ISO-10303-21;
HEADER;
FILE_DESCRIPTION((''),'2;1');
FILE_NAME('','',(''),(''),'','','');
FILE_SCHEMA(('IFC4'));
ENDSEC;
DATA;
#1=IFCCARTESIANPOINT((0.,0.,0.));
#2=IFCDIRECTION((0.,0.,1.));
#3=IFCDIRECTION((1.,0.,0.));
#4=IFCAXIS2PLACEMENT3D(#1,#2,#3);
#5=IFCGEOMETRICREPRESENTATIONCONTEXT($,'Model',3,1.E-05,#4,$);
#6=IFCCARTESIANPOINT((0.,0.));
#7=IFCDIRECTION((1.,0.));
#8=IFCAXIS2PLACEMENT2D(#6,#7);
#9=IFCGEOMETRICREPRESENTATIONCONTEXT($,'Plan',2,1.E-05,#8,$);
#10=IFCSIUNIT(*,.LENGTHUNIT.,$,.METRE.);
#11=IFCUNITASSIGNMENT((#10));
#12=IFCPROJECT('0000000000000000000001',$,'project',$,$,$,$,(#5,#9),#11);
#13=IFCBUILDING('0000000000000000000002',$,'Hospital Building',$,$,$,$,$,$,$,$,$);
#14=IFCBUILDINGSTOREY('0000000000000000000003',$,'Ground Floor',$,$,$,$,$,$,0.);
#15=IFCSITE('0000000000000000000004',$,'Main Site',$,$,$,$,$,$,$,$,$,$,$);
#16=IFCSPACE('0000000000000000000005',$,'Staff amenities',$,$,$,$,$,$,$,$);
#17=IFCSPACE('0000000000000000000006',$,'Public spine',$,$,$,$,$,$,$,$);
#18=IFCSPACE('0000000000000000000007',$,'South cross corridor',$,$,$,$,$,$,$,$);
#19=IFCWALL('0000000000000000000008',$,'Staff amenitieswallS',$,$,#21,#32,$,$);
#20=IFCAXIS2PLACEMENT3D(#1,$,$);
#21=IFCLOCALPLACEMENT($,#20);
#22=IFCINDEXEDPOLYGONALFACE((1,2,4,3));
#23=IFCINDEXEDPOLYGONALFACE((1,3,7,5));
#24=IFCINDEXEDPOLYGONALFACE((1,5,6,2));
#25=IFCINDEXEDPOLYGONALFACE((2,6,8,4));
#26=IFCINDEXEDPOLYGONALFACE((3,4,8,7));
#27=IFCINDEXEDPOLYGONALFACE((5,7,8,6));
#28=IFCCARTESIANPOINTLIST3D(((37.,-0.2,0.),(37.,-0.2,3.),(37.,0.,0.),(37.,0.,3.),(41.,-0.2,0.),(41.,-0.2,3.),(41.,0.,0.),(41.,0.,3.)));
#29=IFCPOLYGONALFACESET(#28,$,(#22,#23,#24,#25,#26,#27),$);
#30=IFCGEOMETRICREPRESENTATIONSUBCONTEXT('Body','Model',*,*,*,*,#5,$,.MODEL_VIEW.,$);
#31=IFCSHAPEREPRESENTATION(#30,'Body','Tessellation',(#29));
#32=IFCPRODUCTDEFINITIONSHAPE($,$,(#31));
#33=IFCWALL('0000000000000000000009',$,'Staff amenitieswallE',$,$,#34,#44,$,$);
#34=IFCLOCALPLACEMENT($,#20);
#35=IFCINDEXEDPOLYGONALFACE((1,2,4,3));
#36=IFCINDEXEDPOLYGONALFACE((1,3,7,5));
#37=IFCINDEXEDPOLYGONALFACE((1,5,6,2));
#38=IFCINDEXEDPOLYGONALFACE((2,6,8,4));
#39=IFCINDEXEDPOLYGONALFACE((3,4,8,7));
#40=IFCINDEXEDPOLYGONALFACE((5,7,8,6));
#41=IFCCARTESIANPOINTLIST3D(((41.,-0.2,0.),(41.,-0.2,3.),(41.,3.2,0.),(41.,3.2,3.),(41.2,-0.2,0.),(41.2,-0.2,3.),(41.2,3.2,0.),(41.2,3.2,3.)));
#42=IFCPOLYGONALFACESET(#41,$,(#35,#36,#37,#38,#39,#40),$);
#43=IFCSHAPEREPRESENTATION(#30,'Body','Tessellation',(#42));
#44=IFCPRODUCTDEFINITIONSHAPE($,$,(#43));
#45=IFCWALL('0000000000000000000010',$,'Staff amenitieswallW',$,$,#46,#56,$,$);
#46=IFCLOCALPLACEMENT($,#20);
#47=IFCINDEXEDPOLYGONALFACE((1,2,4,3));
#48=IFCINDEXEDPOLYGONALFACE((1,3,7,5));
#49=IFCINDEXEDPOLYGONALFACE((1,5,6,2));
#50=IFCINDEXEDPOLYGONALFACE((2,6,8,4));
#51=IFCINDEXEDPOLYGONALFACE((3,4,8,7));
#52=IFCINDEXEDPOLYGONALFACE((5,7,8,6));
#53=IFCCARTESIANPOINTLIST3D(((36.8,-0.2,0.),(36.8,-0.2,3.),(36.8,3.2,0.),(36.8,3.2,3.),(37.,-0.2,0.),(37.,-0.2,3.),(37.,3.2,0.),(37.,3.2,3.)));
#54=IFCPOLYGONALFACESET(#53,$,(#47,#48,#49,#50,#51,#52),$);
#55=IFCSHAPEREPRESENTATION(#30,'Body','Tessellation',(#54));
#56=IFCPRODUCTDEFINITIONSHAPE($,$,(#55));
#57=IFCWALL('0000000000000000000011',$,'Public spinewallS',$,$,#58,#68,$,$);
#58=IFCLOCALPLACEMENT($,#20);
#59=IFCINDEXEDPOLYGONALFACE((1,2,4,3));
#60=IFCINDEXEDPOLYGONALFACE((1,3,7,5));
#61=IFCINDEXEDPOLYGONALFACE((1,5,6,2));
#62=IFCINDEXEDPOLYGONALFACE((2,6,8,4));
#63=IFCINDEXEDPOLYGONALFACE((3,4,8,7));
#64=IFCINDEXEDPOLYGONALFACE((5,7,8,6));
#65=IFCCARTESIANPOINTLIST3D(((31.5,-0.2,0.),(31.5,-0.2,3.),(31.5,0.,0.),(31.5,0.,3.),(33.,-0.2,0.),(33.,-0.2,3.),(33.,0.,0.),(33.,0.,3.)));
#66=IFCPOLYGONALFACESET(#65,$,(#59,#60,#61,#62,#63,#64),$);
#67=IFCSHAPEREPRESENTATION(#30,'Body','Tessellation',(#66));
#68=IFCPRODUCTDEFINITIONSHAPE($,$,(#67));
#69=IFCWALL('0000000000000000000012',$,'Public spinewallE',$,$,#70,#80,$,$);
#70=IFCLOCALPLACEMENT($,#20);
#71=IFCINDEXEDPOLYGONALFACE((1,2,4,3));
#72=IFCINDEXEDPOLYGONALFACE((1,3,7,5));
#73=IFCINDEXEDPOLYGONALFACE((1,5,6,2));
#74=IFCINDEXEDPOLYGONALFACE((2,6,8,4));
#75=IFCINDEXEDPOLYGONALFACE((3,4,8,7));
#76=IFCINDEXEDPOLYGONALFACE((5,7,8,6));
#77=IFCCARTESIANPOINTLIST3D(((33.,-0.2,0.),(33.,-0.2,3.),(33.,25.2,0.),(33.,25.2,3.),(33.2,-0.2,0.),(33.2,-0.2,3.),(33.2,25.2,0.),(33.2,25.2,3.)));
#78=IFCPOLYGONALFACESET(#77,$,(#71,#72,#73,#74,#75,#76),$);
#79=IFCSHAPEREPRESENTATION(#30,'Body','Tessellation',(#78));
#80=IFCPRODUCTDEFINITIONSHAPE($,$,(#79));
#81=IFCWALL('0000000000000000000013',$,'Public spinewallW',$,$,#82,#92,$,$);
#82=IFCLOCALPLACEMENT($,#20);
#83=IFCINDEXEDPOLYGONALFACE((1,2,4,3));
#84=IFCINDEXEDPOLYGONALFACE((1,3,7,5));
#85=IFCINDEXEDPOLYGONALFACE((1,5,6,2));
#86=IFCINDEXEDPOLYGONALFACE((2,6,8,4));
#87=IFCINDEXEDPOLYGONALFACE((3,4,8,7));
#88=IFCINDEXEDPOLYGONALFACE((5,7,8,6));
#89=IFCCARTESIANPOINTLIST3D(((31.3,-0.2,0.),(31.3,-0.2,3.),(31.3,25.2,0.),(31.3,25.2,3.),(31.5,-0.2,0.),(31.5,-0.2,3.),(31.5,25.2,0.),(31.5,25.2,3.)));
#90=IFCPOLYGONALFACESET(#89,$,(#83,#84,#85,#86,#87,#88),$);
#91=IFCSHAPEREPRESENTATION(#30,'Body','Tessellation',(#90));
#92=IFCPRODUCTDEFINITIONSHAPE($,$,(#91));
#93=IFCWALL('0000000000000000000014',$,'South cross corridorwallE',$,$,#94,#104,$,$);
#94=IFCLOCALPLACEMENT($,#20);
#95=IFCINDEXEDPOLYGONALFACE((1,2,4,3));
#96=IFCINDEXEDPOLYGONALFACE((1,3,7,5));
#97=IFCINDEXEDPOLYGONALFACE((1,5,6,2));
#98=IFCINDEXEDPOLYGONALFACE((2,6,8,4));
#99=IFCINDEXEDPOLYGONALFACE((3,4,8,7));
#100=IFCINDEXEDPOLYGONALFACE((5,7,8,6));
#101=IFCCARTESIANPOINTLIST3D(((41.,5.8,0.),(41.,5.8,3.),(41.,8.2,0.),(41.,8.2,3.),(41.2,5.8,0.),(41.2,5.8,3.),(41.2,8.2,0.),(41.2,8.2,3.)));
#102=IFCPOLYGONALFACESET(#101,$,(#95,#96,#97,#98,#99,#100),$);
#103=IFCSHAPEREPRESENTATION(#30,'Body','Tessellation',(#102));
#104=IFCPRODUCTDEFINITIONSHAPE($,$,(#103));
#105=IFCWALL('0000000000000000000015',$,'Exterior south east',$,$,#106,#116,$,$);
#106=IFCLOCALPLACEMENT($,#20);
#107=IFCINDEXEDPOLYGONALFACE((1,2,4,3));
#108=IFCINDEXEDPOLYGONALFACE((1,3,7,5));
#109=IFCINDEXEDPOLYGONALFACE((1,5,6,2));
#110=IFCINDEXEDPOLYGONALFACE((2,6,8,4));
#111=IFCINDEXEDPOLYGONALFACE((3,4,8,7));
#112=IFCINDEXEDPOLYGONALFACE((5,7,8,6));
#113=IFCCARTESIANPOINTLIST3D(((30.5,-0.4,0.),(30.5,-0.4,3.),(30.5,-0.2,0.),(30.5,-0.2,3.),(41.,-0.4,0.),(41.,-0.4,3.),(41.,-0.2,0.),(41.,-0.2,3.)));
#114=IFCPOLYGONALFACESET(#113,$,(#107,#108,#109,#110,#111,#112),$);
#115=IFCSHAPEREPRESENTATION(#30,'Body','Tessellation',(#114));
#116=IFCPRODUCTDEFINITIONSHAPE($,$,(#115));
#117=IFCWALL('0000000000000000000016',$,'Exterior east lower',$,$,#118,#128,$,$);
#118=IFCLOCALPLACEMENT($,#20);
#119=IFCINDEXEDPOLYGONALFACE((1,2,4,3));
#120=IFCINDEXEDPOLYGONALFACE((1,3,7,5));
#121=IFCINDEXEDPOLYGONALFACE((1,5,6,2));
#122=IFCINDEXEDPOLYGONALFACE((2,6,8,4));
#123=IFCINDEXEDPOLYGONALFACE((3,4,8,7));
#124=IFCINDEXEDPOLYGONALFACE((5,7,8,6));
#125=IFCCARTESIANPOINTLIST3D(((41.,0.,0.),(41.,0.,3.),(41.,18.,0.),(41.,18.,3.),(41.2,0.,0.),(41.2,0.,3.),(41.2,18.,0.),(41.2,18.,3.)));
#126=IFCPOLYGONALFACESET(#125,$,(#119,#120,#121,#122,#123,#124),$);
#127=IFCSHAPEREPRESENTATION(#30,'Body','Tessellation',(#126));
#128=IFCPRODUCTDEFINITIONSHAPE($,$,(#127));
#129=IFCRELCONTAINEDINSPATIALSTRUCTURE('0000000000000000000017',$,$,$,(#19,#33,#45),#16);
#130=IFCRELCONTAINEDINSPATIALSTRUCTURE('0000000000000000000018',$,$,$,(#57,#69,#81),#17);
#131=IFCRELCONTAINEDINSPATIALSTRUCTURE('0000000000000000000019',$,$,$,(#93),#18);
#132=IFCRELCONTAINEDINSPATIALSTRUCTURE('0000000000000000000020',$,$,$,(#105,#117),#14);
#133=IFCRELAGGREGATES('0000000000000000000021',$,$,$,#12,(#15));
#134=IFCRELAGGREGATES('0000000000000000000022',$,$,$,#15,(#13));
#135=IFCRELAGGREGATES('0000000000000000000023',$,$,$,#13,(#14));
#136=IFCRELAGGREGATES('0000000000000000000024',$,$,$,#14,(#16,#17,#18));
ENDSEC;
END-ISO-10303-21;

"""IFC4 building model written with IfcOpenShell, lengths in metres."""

from ifc_helpers import new_model, si_unit, frame, origin_with_axes, origin_2d_with_axis, place, context, subcontext, project, spatial, indexed_curve, outline, extrude, element, save


model = new_model("IFC4")

# Units and contexts
model_context = context("Model", 3, precision=1e-05, world=origin_with_axes())
plan_context = context("Plan", 2, precision=1e-05, world=origin_2d_with_axis())
body_context = subcontext(model_context, "Body", "Model", "MODEL_VIEW")
ifc_project = project(units=[si_unit("LENGTHUNIT", "METRE")], contexts=[model_context, plan_context])

# Site, building, storey
site = spatial("IfcSite", under=ifc_project, Name="Main Site")
building = spatial("IfcBuilding", under=site, Name="Hospital Building")
storey = spatial("IfcBuildingStorey", under=building, Name="Ground Floor", Elevation=0.0)

# Shared definitions
space_1 = spatial("IfcSpace", under=storey, Name="Staff amenities")

# Walls
wall_1_placement = place(None, frame((37.0, -0.2, 0.0), z_axis=(0.0, 0.0, 1.0), x_axis=(1.0, 0.0, 0.0)))
element("IfcWall", 1, at=wall_1_placement, inside=space_1, Name="Staff amenitieswallS", context=body_context, shape_type="SweptSolid", body=[
    extrude(outline(indexed_curve([(0.0, 0.0), (0.0, 0.2), (4.0, 0.2), (4.0, 0.0), (0.0, 0.0)], self_intersect=False)), origin_with_axes(), (0.0, 0.0, 1.0), 3.0),
])
for number, where, z_axis, x_axis, name in (
    (2, (41.2, -0.2, 0.0), (0.0, 0.0, 1.0), (0.0, 1.0, 0.0), "Staff amenitieswallE"),
    (3, (37.0, -0.2, 0.0), (0.0, 0.0, 1.0), (0.0, 1.0, 0.0), "Staff amenitieswallW"),
):
    element("IfcWall", number, at=place(None, frame(where, z_axis=z_axis, x_axis=x_axis)), inside=space_1, Name=name, context=body_context, shape_type="SweptSolid", body=[
        extrude(outline(indexed_curve([(0.0, 0.0), (0.0, 0.2), (3.4, 0.2), (3.4, 0.0), (0.0, 0.0)], self_intersect=False)), origin_with_axes(), (0.0, 0.0, 1.0), 3.0),
    ])

# Shared definitions
space_2 = spatial("IfcSpace", under=storey, Name="Public spine")

# Walls
wall_2_placement = place(None, frame((31.5, -0.2, 0.0), z_axis=(0.0, 0.0, 1.0), x_axis=(1.0, 0.0, 0.0)))
element("IfcWall", 4, at=wall_2_placement, inside=space_2, Name="Public spinewallS", context=body_context, shape_type="SweptSolid", body=[
    extrude(outline(indexed_curve([(0.0, 0.0), (0.0, 0.2), (1.5, 0.2), (1.5, 0.0), (0.0, 0.0)], self_intersect=False)), origin_with_axes(), (0.0, 0.0, 1.0), 3.0),
])
for number, where, z_axis, x_axis, name in (
    (5, (33.2, -0.2, 0.0), (0.0, 0.0, 1.0), (0.0, 1.0, 0.0), "Public spinewallE"),
    (6, (31.5, -0.2, 0.0), (0.0, 0.0, 1.0), (0.0, 1.0, 0.0), "Public spinewallW"),
):
    element("IfcWall", number, at=place(None, frame(where, z_axis=z_axis, x_axis=x_axis)), inside=space_2, Name=name, context=body_context, shape_type="SweptSolid", body=[
        extrude(outline(indexed_curve([(0.0, 0.0), (0.0, 0.2), (25.4, 0.2), (25.4, 0.0), (0.0, 0.0)], self_intersect=False)), origin_with_axes(), (0.0, 0.0, 1.0), 3.0),
    ])

# Shared definitions
space_3 = spatial("IfcSpace", under=storey, Name="South cross corridor")

# Walls
wall_3_placement = place(None, frame((41.2, 5.8, 0.0), z_axis=(0.0, 0.0, 1.0), x_axis=(0.0, 1.0, 0.0)))
element("IfcWall", 7, at=wall_3_placement, inside=space_3, Name="South cross corridorwallE", context=body_context, shape_type="SweptSolid", body=[
    extrude(outline(indexed_curve([(0.0, 0.0), (0.0, 0.2), (2.4, 0.2), (2.4, 0.0), (0.0, 0.0)], self_intersect=False)), origin_with_axes(), (0.0, 0.0, 1.0), 3.0),
])
wall_4_placement = place(None, frame((30.5, -0.4, 0.0), z_axis=(0.0, 0.0, 1.0), x_axis=(1.0, 0.0, 0.0)))
element("IfcWall", 8, at=wall_4_placement, inside=storey, Name="Exterior south east", context=body_context, shape_type="SweptSolid", body=[
    extrude(outline(indexed_curve([(0.0, 0.0), (0.0, 0.2), (10.5, 0.2), (10.5, 0.0), (0.0, 0.0)], self_intersect=False)), origin_with_axes(), (0.0, 0.0, 1.0), 3.0),
])
wall_5_placement = place(None, frame((41.2, 0.0, 0.0), z_axis=(0.0, 0.0, 1.0), x_axis=(0.0, 1.0, 0.0)))
element("IfcWall", 9, at=wall_5_placement, inside=storey, Name="Exterior east lower", context=body_context, shape_type="SweptSolid", body=[
    extrude(outline(indexed_curve([(0.0, 0.0), (0.0, 0.2), (18.0, 0.2), (18.0, 0.0), (0.0, 0.0)], self_intersect=False)), origin_with_axes(), (0.0, 0.0, 1.0), 3.0),
])

save(model, "model.ifc")
